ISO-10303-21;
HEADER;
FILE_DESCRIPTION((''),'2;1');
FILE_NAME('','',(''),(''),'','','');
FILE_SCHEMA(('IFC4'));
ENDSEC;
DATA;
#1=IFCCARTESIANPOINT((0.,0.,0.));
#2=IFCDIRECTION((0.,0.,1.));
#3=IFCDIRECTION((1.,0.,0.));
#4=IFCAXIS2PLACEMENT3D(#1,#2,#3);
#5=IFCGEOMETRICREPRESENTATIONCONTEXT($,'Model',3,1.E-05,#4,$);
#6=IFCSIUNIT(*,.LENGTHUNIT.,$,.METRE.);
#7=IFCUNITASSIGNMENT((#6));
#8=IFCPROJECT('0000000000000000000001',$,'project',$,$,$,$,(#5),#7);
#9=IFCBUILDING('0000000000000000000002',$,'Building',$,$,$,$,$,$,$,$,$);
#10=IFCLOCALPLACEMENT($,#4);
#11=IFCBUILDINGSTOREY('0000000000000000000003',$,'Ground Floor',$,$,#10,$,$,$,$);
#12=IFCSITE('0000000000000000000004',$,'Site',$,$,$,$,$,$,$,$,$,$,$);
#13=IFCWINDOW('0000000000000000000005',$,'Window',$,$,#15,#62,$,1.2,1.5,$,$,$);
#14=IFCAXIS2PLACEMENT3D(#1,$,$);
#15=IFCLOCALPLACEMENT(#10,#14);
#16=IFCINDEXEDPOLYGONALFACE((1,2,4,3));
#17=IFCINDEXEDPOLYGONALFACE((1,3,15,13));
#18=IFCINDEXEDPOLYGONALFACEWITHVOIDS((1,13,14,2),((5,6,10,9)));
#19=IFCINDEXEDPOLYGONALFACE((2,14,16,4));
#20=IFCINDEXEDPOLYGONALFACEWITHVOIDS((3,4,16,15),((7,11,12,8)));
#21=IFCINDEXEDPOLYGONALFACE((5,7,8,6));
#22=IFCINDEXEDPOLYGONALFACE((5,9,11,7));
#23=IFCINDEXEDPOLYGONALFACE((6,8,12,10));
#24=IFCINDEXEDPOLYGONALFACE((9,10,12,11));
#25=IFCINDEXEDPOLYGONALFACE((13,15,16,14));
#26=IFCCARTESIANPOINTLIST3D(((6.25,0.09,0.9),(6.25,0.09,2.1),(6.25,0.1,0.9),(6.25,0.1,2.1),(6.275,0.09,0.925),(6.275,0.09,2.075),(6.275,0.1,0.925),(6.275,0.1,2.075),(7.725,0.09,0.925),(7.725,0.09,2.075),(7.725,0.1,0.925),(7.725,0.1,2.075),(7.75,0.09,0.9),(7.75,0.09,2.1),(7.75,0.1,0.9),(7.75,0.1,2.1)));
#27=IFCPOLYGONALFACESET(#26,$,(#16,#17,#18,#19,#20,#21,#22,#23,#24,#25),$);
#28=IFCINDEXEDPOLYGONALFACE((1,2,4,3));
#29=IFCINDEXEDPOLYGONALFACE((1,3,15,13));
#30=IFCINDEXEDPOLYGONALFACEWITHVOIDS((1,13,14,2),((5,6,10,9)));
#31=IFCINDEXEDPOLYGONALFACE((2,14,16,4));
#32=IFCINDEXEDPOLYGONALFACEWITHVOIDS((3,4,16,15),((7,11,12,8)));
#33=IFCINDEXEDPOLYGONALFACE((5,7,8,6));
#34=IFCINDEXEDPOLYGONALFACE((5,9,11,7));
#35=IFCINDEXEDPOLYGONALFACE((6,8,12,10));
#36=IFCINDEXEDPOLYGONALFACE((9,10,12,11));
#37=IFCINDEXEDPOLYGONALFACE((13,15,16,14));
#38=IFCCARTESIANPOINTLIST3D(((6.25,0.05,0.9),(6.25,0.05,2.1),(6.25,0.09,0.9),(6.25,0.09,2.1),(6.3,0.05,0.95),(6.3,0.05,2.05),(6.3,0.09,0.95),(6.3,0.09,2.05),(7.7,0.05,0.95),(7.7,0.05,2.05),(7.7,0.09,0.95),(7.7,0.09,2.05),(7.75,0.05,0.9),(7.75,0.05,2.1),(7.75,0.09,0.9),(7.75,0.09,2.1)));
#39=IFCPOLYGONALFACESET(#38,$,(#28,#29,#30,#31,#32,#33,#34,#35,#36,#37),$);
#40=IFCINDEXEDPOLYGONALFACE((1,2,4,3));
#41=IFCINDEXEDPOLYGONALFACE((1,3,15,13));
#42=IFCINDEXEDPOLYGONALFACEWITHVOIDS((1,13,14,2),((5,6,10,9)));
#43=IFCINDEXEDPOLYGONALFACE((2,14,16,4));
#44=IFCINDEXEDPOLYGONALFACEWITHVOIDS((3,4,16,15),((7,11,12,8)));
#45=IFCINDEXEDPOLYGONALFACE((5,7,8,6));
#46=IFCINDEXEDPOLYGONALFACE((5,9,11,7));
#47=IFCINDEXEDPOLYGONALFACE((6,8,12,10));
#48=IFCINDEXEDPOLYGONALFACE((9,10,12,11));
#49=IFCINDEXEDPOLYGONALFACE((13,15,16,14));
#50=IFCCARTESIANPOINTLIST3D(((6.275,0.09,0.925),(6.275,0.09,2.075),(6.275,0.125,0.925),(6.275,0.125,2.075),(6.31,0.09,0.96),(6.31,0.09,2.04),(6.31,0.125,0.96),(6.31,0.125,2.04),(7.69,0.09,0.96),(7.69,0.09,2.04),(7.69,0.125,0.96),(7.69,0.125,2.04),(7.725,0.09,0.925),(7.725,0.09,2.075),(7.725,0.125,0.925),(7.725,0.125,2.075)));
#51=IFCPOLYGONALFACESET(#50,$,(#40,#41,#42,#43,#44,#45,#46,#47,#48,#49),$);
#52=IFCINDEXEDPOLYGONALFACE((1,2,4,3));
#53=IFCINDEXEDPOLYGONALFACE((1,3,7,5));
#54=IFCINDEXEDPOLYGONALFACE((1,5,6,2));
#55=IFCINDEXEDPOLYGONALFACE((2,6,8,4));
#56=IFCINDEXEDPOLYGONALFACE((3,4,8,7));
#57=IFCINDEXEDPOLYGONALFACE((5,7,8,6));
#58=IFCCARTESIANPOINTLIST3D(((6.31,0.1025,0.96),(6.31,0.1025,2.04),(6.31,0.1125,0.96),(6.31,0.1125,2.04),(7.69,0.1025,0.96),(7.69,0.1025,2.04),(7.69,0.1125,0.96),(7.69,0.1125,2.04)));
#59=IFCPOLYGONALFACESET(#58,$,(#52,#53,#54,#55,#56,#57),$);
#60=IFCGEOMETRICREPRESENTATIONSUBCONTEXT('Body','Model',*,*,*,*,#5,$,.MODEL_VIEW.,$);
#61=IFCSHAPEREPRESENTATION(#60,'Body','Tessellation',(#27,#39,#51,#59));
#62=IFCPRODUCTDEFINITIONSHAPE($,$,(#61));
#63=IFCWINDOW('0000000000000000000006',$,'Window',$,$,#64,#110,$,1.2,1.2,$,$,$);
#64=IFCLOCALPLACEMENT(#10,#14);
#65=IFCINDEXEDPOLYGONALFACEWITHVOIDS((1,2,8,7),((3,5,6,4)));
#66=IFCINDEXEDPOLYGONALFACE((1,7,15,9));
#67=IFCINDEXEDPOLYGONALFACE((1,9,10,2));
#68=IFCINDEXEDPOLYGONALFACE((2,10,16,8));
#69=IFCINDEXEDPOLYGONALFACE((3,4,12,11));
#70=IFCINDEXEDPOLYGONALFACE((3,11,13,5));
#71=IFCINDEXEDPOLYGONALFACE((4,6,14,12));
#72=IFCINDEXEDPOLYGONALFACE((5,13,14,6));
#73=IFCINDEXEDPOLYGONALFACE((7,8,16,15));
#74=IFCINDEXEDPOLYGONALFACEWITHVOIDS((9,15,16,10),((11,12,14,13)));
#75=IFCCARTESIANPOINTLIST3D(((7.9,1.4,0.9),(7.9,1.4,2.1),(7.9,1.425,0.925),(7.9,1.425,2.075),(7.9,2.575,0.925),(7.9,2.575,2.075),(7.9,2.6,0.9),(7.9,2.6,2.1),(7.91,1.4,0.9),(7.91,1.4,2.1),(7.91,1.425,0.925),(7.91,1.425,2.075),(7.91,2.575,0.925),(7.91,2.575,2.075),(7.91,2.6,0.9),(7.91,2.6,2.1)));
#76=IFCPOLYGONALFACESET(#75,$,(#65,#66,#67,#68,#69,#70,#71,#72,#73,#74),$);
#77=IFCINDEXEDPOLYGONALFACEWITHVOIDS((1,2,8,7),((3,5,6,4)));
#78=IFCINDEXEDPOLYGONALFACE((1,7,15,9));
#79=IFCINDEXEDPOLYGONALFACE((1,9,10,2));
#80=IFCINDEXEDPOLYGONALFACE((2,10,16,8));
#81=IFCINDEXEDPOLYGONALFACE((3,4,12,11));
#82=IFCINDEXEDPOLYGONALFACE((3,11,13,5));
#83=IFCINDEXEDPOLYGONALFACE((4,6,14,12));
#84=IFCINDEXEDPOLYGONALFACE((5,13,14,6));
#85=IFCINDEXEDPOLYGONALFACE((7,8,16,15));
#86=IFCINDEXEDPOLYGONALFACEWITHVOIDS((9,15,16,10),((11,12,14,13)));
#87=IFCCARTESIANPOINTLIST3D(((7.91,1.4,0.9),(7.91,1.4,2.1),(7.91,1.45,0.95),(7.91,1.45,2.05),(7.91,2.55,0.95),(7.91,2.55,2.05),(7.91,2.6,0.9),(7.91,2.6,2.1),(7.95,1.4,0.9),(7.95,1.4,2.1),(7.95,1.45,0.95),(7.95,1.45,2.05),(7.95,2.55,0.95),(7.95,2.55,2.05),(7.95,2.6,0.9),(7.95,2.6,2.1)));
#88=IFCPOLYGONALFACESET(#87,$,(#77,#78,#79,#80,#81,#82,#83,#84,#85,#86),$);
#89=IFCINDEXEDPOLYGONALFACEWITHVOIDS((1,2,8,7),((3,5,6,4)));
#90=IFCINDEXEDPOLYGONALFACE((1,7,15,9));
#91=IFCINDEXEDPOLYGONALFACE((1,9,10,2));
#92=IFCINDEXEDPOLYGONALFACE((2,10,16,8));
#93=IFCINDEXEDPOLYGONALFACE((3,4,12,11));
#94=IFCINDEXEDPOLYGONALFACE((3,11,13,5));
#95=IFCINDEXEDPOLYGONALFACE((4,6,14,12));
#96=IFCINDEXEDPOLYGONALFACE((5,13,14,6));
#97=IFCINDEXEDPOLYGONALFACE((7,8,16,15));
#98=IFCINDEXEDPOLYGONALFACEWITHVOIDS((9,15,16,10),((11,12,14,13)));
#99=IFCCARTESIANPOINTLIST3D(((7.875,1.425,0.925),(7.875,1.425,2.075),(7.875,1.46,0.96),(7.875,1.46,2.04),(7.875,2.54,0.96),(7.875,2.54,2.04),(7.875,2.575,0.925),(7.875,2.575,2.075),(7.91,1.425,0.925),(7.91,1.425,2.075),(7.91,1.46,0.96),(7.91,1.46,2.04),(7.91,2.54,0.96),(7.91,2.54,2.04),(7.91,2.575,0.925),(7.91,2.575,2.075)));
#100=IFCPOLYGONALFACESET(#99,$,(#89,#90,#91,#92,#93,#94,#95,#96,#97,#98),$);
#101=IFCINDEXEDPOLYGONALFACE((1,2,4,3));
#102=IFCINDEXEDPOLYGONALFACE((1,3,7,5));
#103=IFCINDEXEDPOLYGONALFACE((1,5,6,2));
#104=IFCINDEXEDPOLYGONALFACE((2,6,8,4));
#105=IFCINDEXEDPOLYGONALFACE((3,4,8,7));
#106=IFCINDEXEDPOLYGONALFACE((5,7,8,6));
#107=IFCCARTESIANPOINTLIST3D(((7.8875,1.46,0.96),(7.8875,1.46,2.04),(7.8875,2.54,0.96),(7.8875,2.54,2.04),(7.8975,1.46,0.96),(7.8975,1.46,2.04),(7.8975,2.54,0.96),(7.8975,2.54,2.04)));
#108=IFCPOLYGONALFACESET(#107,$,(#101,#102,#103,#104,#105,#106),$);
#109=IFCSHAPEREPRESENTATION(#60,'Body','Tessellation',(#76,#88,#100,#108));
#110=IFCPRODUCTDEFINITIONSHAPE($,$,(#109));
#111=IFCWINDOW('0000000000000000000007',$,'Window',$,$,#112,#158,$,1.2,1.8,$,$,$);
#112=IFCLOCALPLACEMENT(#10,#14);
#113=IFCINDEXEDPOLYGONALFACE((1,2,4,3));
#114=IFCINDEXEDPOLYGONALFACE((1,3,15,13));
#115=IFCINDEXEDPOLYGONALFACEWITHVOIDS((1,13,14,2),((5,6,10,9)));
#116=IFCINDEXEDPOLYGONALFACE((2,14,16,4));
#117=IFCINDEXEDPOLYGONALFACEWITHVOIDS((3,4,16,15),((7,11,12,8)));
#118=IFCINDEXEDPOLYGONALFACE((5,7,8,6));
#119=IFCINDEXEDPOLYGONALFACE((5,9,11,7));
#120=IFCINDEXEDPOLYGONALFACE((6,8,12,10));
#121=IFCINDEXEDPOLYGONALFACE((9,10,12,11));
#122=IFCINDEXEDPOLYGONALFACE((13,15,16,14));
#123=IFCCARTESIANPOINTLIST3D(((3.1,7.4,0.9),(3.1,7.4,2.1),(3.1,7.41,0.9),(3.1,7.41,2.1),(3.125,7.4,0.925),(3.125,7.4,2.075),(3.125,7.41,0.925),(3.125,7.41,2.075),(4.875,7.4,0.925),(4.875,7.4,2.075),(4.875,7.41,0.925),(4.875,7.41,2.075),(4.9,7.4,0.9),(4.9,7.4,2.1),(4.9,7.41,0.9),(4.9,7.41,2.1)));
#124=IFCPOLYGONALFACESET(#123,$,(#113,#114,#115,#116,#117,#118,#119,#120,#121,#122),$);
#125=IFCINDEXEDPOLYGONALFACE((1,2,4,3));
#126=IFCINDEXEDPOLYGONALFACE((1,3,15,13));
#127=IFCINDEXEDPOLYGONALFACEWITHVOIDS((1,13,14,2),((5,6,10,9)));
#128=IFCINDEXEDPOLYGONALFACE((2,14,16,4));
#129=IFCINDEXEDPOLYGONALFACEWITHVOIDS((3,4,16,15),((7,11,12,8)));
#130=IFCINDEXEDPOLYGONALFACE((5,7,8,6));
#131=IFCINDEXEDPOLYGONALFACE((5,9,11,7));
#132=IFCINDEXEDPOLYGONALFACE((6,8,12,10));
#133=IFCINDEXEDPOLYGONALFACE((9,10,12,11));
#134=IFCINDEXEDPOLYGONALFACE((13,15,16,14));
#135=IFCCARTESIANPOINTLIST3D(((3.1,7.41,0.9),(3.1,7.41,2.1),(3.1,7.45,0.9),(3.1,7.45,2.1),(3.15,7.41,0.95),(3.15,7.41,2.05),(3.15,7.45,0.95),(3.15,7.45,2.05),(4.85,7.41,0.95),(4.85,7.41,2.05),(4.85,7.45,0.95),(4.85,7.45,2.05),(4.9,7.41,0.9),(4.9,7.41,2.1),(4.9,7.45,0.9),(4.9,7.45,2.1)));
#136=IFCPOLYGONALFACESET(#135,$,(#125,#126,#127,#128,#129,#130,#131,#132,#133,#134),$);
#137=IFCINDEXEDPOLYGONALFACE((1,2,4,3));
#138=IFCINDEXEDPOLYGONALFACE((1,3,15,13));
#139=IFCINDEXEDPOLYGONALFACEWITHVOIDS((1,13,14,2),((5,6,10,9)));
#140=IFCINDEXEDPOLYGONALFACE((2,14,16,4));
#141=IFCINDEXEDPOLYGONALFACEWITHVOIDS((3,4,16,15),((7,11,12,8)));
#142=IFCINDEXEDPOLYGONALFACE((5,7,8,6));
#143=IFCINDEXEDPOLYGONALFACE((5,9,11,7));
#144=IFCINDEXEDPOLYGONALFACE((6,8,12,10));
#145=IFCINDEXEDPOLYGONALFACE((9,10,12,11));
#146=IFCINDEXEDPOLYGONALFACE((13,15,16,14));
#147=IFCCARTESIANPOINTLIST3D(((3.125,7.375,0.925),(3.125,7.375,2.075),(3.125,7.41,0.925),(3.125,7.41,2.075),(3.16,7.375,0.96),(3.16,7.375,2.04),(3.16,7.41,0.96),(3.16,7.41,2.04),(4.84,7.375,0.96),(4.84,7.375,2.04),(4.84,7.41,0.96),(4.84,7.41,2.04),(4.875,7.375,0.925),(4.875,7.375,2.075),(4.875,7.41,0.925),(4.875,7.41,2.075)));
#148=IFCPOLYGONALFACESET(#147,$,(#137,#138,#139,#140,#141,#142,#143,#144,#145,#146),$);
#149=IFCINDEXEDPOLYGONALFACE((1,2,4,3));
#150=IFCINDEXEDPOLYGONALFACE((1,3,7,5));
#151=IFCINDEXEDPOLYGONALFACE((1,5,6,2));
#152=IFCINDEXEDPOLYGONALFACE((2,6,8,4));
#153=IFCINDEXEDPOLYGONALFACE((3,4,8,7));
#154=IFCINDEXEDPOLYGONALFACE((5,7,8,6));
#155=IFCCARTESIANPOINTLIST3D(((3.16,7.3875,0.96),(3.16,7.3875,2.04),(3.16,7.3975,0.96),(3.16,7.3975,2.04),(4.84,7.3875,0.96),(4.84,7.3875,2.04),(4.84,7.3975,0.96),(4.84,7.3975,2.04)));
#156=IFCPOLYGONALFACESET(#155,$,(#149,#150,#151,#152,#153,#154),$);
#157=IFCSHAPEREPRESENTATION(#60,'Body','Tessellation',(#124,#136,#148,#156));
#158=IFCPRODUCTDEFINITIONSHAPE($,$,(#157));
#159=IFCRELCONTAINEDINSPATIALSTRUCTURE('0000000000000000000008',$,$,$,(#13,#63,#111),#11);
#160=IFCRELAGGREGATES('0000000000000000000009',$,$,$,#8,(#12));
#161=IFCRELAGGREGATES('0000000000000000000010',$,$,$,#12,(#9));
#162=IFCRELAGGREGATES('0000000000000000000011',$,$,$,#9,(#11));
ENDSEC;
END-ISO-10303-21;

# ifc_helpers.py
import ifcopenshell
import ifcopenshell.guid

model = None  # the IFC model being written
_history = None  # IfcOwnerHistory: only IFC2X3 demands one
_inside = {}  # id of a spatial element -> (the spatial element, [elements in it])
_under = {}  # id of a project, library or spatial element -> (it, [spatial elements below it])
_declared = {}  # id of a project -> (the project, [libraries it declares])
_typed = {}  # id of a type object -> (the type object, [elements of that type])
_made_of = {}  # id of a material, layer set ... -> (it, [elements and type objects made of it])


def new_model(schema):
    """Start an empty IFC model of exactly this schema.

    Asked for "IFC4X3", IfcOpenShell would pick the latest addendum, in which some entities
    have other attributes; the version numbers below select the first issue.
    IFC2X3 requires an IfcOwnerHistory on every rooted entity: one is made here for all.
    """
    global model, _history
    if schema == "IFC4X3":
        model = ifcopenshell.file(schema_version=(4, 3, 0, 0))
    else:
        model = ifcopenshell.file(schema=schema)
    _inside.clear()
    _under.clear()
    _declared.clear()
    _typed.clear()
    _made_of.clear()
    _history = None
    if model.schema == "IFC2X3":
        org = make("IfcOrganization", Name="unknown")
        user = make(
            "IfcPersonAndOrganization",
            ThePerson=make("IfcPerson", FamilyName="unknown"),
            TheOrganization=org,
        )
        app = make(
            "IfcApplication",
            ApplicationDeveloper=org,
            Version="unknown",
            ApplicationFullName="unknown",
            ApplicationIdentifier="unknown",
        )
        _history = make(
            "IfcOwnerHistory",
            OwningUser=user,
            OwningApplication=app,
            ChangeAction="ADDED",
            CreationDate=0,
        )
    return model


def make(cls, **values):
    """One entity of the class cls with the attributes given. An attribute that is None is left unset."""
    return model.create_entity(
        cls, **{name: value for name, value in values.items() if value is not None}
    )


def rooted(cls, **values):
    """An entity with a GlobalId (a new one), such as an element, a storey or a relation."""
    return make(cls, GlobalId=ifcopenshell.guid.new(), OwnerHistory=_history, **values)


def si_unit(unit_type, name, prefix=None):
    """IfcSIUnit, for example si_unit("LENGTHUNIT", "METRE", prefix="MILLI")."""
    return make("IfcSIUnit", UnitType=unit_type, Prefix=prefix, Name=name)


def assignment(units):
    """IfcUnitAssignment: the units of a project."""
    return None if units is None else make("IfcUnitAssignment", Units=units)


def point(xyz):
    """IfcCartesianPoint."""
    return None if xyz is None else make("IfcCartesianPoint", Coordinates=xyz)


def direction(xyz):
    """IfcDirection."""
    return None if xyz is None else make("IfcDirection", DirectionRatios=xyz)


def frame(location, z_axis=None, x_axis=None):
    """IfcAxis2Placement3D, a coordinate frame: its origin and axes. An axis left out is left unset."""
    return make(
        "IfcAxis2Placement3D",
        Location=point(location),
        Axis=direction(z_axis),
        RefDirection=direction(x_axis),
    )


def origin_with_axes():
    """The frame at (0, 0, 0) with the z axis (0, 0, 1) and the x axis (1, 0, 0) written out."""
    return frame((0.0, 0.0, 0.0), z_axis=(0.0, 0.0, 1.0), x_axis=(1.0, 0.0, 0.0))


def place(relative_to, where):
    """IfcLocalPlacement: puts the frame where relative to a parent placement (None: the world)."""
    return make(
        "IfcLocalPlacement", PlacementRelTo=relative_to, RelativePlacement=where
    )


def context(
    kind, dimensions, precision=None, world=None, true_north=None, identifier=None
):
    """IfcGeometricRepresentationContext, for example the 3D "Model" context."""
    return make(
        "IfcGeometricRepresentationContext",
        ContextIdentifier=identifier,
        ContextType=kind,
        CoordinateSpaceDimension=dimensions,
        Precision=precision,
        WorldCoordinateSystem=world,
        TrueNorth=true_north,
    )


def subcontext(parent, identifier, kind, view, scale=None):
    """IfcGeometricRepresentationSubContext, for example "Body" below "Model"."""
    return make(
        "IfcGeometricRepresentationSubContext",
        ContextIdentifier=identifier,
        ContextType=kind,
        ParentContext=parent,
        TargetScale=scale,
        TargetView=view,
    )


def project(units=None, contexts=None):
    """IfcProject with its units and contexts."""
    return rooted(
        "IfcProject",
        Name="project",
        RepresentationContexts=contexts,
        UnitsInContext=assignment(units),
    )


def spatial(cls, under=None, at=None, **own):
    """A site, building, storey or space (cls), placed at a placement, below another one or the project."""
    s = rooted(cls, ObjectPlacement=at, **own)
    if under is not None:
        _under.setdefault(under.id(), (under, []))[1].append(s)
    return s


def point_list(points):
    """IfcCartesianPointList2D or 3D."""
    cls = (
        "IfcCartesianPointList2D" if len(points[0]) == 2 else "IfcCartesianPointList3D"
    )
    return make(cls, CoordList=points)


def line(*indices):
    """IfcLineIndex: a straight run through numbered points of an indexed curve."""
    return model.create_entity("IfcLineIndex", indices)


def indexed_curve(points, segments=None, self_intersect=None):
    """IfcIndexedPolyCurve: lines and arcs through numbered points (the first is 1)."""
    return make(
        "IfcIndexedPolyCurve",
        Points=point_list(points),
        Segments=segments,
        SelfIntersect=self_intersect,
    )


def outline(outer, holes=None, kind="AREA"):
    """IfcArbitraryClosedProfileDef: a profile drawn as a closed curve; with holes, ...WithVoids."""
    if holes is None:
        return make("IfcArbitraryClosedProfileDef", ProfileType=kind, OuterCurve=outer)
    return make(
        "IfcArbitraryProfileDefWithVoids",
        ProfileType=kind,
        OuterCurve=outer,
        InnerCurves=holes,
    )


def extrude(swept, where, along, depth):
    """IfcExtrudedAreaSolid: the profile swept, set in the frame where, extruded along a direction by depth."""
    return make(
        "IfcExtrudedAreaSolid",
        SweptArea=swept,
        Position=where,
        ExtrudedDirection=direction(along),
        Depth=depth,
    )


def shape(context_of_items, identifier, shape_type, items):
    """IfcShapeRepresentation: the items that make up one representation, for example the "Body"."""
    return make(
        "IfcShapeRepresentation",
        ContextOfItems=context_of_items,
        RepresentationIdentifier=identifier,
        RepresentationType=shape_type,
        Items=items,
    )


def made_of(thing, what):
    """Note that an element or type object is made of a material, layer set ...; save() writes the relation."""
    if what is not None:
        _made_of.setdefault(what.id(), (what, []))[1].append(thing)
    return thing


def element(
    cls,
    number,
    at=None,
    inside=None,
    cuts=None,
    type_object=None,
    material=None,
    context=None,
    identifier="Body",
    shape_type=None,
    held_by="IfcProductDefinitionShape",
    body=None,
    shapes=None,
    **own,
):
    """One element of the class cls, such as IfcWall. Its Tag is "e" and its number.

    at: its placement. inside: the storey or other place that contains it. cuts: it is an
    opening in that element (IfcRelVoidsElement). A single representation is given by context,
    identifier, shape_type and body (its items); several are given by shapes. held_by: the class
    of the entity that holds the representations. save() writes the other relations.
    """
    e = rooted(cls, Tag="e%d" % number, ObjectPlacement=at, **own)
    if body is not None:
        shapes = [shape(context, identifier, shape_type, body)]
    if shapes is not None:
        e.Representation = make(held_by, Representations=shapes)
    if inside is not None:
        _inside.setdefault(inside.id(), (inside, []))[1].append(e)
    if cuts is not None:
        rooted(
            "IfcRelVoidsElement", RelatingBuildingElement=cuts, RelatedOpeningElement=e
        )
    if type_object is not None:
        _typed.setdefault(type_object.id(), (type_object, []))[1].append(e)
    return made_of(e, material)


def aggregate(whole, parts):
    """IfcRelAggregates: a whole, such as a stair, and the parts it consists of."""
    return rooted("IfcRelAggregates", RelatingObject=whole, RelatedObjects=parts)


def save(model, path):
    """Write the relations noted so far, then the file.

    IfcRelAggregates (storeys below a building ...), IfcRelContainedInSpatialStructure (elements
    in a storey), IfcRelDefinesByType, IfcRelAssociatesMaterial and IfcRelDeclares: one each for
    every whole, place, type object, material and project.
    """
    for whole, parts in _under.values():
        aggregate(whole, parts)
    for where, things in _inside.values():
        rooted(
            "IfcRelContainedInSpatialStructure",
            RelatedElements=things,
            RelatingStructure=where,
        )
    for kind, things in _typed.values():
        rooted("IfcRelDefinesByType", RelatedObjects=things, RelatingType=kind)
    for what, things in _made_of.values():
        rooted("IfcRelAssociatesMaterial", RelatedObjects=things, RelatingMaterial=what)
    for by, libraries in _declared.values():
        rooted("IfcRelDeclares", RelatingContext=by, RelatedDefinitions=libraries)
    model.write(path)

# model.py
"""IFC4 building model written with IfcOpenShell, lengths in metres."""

from ifc_helpers import new_model, si_unit, frame, origin_with_axes, place, context, subcontext, project, spatial, line, indexed_curve, outline, extrude, element, save


model = new_model("IFC4")

# Units and contexts
model_context = context("Model", 3, precision=1e-05, world=origin_with_axes())
body_context = subcontext(model_context, "Body", "Model", "MODEL_VIEW")
ifc_project = project(units=[si_unit("LENGTHUNIT", "METRE")], contexts=[model_context])

# Site, building, storey
site = spatial("IfcSite", under=ifc_project, Name="Site")
building = spatial("IfcBuilding", under=site, Name="Building")
storey_placement = place(None, origin_with_axes())
storey = spatial("IfcBuildingStorey", under=building, at=storey_placement, Name="Ground Floor")

# Windows
window_1_placement = place(storey_placement, frame((6.25, 0.0, 0.9), z_axis=(0.0, 0.0, 1.0), x_axis=(1.0, 0.0, 0.0)))
element("IfcWindow", 1, at=window_1_placement, inside=storey, Name="Window", OverallHeight=1.2, OverallWidth=1.5, context=body_context, shape_type="SweptSolid", body=[
    extrude(outline(indexed_curve([(0.0, 0.0), (1.5, 0.0), (1.5, 1.2), (0.0, 1.2)], segments=[line(1, 2, 3, 4, 1)]), holes=[indexed_curve([(0.025, 0.025), (1.475, 0.025), (1.475, 1.175), (0.025, 1.175)], segments=[line(1, 2, 3, 4, 1)])]), frame((0.0, 0.09, 0.0), z_axis=(0.0, -1.0, 0.0), x_axis=(1.0, 0.0, 0.0)), (0.0, 0.0, -1.0), 0.01),
    extrude(outline(indexed_curve([(0.0, 0.0), (1.5, 0.0), (1.5, 1.2), (0.0, 1.2)], segments=[line(1, 2, 3, 4, 1)]), holes=[indexed_curve([(0.05, 0.05), (1.45, 0.05), (1.45, 1.15), (0.05, 1.15)], segments=[line(1, 2, 3, 4, 1)])]), frame((0.0, 0.05, 0.0), z_axis=(0.0, -1.0, 0.0), x_axis=(1.0, 0.0, 0.0)), (0.0, 0.0, -1.0), 0.04),
    extrude(outline(indexed_curve([(0.0, 0.0), (1.45, 0.0), (1.45, 1.15), (0.0, 1.15)], segments=[line(1, 2, 3, 4, 1)]), holes=[indexed_curve([(0.035, 0.035), (1.415, 0.035), (1.415, 1.115), (0.035, 1.115)], segments=[line(1, 2, 3, 4, 1)])]), frame((0.025, 0.09, 0.025), z_axis=(0.0, -1.0, 0.0), x_axis=(1.0, 0.0, 0.0)), (0.0, 0.0, -1.0), 0.035),
    extrude(outline(indexed_curve([(0.035, 0.035), (1.415, 0.035), (1.415, 1.115), (0.035, 1.115)], segments=[line(1, 2, 3, 4, 1)])), frame((0.025, 0.1025, 0.025), z_axis=(0.0, -1.0, 0.0), x_axis=(1.0, 0.0, 0.0)), (0.0, 0.0, -1.0), 0.01),
])
window_2_placement = place(storey_placement, frame((8.0, 1.4, 0.9), z_axis=(0.0, 0.0, 1.0), x_axis=(0.0, 1.0, 0.0)))
element("IfcWindow", 2, at=window_2_placement, inside=storey, Name="Window", OverallHeight=1.2, OverallWidth=1.2, context=body_context, shape_type="SweptSolid", body=[
    extrude(outline(indexed_curve([(0.0, 0.0), (1.2, 0.0), (1.2, 1.2), (0.0, 1.2)], segments=[line(1, 2, 3, 4, 1)]), holes=[indexed_curve([(0.025, 0.025), (1.175, 0.025), (1.175, 1.175), (0.025, 1.175)], segments=[line(1, 2, 3, 4, 1)])]), frame((0.0, 0.09, 0.0), z_axis=(0.0, -1.0, 0.0), x_axis=(1.0, 0.0, 0.0)), (0.0, 0.0, -1.0), 0.01),
    extrude(outline(indexed_curve([(0.0, 0.0), (1.2, 0.0), (1.2, 1.2), (0.0, 1.2)], segments=[line(1, 2, 3, 4, 1)]), holes=[indexed_curve([(0.05, 0.05), (1.15, 0.05), (1.15, 1.15), (0.05, 1.15)], segments=[line(1, 2, 3, 4, 1)])]), frame((0.0, 0.05, 0.0), z_axis=(0.0, -1.0, 0.0), x_axis=(1.0, 0.0, 0.0)), (0.0, 0.0, -1.0), 0.04),
    extrude(outline(indexed_curve([(0.0, 0.0), (1.15, 0.0), (1.15, 1.15), (0.0, 1.15)], segments=[line(1, 2, 3, 4, 1)]), holes=[indexed_curve([(0.035, 0.035), (1.115, 0.035), (1.115, 1.115), (0.035, 1.115)], segments=[line(1, 2, 3, 4, 1)])]), frame((0.025, 0.09, 0.025), z_axis=(0.0, -1.0, 0.0), x_axis=(1.0, 0.0, 0.0)), (0.0, 0.0, -1.0), 0.035),
    extrude(outline(indexed_curve([(0.035, 0.035), (1.115, 0.035), (1.115, 1.115), (0.035, 1.115)], segments=[line(1, 2, 3, 4, 1)])), frame((0.025, 0.1025, 0.025), z_axis=(0.0, -1.0, 0.0), x_axis=(1.0, 0.0, 0.0)), (0.0, 0.0, -1.0), 0.01),
])
window_3_placement = place(storey_placement, frame((4.9, 7.5, 0.9), z_axis=(0.0, 0.0, 1.0), x_axis=(-1.0, 0.0, 0.0)))
element("IfcWindow", 3, at=window_3_placement, inside=storey, Name="Window", OverallHeight=1.2, OverallWidth=1.8, context=body_context, shape_type="SweptSolid", body=[
    extrude(outline(indexed_curve([(0.0, 0.0), (1.8, 0.0), (1.8, 1.2), (0.0, 1.2)], segments=[line(1, 2, 3, 4, 1)]), holes=[indexed_curve([(0.025, 0.025), (1.775, 0.025), (1.775, 1.175), (0.025, 1.175)], segments=[line(1, 2, 3, 4, 1)])]), frame((0.0, 0.09, 0.0), z_axis=(0.0, -1.0, 0.0), x_axis=(1.0, 0.0, 0.0)), (0.0, 0.0, -1.0), 0.01),
    extrude(outline(indexed_curve([(0.0, 0.0), (1.8, 0.0), (1.8, 1.2), (0.0, 1.2)], segments=[line(1, 2, 3, 4, 1)]), holes=[indexed_curve([(0.05, 0.05), (1.75, 0.05), (1.75, 1.15), (0.05, 1.15)], segments=[line(1, 2, 3, 4, 1)])]), frame((0.0, 0.05, 0.0), z_axis=(0.0, -1.0, 0.0), x_axis=(1.0, 0.0, 0.0)), (0.0, 0.0, -1.0), 0.04),
    extrude(outline(indexed_curve([(0.0, 0.0), (1.75, 0.0), (1.75, 1.15), (0.0, 1.15)], segments=[line(1, 2, 3, 4, 1)]), holes=[indexed_curve([(0.035, 0.035), (1.715, 0.035), (1.715, 1.115), (0.035, 1.115)], segments=[line(1, 2, 3, 4, 1)])]), frame((0.025, 0.09, 0.025), z_axis=(0.0, -1.0, 0.0), x_axis=(1.0, 0.0, 0.0)), (0.0, 0.0, -1.0), 0.035),
    extrude(outline(indexed_curve([(0.035, 0.035), (1.715, 0.035), (1.715, 1.115), (0.035, 1.115)], segments=[line(1, 2, 3, 4, 1)])), frame((0.025, 0.1025, 0.025), z_axis=(0.0, -1.0, 0.0), x_axis=(1.0, 0.0, 0.0)), (0.0, 0.0, -1.0), 0.01),
])

save(model, "model.ifc")
